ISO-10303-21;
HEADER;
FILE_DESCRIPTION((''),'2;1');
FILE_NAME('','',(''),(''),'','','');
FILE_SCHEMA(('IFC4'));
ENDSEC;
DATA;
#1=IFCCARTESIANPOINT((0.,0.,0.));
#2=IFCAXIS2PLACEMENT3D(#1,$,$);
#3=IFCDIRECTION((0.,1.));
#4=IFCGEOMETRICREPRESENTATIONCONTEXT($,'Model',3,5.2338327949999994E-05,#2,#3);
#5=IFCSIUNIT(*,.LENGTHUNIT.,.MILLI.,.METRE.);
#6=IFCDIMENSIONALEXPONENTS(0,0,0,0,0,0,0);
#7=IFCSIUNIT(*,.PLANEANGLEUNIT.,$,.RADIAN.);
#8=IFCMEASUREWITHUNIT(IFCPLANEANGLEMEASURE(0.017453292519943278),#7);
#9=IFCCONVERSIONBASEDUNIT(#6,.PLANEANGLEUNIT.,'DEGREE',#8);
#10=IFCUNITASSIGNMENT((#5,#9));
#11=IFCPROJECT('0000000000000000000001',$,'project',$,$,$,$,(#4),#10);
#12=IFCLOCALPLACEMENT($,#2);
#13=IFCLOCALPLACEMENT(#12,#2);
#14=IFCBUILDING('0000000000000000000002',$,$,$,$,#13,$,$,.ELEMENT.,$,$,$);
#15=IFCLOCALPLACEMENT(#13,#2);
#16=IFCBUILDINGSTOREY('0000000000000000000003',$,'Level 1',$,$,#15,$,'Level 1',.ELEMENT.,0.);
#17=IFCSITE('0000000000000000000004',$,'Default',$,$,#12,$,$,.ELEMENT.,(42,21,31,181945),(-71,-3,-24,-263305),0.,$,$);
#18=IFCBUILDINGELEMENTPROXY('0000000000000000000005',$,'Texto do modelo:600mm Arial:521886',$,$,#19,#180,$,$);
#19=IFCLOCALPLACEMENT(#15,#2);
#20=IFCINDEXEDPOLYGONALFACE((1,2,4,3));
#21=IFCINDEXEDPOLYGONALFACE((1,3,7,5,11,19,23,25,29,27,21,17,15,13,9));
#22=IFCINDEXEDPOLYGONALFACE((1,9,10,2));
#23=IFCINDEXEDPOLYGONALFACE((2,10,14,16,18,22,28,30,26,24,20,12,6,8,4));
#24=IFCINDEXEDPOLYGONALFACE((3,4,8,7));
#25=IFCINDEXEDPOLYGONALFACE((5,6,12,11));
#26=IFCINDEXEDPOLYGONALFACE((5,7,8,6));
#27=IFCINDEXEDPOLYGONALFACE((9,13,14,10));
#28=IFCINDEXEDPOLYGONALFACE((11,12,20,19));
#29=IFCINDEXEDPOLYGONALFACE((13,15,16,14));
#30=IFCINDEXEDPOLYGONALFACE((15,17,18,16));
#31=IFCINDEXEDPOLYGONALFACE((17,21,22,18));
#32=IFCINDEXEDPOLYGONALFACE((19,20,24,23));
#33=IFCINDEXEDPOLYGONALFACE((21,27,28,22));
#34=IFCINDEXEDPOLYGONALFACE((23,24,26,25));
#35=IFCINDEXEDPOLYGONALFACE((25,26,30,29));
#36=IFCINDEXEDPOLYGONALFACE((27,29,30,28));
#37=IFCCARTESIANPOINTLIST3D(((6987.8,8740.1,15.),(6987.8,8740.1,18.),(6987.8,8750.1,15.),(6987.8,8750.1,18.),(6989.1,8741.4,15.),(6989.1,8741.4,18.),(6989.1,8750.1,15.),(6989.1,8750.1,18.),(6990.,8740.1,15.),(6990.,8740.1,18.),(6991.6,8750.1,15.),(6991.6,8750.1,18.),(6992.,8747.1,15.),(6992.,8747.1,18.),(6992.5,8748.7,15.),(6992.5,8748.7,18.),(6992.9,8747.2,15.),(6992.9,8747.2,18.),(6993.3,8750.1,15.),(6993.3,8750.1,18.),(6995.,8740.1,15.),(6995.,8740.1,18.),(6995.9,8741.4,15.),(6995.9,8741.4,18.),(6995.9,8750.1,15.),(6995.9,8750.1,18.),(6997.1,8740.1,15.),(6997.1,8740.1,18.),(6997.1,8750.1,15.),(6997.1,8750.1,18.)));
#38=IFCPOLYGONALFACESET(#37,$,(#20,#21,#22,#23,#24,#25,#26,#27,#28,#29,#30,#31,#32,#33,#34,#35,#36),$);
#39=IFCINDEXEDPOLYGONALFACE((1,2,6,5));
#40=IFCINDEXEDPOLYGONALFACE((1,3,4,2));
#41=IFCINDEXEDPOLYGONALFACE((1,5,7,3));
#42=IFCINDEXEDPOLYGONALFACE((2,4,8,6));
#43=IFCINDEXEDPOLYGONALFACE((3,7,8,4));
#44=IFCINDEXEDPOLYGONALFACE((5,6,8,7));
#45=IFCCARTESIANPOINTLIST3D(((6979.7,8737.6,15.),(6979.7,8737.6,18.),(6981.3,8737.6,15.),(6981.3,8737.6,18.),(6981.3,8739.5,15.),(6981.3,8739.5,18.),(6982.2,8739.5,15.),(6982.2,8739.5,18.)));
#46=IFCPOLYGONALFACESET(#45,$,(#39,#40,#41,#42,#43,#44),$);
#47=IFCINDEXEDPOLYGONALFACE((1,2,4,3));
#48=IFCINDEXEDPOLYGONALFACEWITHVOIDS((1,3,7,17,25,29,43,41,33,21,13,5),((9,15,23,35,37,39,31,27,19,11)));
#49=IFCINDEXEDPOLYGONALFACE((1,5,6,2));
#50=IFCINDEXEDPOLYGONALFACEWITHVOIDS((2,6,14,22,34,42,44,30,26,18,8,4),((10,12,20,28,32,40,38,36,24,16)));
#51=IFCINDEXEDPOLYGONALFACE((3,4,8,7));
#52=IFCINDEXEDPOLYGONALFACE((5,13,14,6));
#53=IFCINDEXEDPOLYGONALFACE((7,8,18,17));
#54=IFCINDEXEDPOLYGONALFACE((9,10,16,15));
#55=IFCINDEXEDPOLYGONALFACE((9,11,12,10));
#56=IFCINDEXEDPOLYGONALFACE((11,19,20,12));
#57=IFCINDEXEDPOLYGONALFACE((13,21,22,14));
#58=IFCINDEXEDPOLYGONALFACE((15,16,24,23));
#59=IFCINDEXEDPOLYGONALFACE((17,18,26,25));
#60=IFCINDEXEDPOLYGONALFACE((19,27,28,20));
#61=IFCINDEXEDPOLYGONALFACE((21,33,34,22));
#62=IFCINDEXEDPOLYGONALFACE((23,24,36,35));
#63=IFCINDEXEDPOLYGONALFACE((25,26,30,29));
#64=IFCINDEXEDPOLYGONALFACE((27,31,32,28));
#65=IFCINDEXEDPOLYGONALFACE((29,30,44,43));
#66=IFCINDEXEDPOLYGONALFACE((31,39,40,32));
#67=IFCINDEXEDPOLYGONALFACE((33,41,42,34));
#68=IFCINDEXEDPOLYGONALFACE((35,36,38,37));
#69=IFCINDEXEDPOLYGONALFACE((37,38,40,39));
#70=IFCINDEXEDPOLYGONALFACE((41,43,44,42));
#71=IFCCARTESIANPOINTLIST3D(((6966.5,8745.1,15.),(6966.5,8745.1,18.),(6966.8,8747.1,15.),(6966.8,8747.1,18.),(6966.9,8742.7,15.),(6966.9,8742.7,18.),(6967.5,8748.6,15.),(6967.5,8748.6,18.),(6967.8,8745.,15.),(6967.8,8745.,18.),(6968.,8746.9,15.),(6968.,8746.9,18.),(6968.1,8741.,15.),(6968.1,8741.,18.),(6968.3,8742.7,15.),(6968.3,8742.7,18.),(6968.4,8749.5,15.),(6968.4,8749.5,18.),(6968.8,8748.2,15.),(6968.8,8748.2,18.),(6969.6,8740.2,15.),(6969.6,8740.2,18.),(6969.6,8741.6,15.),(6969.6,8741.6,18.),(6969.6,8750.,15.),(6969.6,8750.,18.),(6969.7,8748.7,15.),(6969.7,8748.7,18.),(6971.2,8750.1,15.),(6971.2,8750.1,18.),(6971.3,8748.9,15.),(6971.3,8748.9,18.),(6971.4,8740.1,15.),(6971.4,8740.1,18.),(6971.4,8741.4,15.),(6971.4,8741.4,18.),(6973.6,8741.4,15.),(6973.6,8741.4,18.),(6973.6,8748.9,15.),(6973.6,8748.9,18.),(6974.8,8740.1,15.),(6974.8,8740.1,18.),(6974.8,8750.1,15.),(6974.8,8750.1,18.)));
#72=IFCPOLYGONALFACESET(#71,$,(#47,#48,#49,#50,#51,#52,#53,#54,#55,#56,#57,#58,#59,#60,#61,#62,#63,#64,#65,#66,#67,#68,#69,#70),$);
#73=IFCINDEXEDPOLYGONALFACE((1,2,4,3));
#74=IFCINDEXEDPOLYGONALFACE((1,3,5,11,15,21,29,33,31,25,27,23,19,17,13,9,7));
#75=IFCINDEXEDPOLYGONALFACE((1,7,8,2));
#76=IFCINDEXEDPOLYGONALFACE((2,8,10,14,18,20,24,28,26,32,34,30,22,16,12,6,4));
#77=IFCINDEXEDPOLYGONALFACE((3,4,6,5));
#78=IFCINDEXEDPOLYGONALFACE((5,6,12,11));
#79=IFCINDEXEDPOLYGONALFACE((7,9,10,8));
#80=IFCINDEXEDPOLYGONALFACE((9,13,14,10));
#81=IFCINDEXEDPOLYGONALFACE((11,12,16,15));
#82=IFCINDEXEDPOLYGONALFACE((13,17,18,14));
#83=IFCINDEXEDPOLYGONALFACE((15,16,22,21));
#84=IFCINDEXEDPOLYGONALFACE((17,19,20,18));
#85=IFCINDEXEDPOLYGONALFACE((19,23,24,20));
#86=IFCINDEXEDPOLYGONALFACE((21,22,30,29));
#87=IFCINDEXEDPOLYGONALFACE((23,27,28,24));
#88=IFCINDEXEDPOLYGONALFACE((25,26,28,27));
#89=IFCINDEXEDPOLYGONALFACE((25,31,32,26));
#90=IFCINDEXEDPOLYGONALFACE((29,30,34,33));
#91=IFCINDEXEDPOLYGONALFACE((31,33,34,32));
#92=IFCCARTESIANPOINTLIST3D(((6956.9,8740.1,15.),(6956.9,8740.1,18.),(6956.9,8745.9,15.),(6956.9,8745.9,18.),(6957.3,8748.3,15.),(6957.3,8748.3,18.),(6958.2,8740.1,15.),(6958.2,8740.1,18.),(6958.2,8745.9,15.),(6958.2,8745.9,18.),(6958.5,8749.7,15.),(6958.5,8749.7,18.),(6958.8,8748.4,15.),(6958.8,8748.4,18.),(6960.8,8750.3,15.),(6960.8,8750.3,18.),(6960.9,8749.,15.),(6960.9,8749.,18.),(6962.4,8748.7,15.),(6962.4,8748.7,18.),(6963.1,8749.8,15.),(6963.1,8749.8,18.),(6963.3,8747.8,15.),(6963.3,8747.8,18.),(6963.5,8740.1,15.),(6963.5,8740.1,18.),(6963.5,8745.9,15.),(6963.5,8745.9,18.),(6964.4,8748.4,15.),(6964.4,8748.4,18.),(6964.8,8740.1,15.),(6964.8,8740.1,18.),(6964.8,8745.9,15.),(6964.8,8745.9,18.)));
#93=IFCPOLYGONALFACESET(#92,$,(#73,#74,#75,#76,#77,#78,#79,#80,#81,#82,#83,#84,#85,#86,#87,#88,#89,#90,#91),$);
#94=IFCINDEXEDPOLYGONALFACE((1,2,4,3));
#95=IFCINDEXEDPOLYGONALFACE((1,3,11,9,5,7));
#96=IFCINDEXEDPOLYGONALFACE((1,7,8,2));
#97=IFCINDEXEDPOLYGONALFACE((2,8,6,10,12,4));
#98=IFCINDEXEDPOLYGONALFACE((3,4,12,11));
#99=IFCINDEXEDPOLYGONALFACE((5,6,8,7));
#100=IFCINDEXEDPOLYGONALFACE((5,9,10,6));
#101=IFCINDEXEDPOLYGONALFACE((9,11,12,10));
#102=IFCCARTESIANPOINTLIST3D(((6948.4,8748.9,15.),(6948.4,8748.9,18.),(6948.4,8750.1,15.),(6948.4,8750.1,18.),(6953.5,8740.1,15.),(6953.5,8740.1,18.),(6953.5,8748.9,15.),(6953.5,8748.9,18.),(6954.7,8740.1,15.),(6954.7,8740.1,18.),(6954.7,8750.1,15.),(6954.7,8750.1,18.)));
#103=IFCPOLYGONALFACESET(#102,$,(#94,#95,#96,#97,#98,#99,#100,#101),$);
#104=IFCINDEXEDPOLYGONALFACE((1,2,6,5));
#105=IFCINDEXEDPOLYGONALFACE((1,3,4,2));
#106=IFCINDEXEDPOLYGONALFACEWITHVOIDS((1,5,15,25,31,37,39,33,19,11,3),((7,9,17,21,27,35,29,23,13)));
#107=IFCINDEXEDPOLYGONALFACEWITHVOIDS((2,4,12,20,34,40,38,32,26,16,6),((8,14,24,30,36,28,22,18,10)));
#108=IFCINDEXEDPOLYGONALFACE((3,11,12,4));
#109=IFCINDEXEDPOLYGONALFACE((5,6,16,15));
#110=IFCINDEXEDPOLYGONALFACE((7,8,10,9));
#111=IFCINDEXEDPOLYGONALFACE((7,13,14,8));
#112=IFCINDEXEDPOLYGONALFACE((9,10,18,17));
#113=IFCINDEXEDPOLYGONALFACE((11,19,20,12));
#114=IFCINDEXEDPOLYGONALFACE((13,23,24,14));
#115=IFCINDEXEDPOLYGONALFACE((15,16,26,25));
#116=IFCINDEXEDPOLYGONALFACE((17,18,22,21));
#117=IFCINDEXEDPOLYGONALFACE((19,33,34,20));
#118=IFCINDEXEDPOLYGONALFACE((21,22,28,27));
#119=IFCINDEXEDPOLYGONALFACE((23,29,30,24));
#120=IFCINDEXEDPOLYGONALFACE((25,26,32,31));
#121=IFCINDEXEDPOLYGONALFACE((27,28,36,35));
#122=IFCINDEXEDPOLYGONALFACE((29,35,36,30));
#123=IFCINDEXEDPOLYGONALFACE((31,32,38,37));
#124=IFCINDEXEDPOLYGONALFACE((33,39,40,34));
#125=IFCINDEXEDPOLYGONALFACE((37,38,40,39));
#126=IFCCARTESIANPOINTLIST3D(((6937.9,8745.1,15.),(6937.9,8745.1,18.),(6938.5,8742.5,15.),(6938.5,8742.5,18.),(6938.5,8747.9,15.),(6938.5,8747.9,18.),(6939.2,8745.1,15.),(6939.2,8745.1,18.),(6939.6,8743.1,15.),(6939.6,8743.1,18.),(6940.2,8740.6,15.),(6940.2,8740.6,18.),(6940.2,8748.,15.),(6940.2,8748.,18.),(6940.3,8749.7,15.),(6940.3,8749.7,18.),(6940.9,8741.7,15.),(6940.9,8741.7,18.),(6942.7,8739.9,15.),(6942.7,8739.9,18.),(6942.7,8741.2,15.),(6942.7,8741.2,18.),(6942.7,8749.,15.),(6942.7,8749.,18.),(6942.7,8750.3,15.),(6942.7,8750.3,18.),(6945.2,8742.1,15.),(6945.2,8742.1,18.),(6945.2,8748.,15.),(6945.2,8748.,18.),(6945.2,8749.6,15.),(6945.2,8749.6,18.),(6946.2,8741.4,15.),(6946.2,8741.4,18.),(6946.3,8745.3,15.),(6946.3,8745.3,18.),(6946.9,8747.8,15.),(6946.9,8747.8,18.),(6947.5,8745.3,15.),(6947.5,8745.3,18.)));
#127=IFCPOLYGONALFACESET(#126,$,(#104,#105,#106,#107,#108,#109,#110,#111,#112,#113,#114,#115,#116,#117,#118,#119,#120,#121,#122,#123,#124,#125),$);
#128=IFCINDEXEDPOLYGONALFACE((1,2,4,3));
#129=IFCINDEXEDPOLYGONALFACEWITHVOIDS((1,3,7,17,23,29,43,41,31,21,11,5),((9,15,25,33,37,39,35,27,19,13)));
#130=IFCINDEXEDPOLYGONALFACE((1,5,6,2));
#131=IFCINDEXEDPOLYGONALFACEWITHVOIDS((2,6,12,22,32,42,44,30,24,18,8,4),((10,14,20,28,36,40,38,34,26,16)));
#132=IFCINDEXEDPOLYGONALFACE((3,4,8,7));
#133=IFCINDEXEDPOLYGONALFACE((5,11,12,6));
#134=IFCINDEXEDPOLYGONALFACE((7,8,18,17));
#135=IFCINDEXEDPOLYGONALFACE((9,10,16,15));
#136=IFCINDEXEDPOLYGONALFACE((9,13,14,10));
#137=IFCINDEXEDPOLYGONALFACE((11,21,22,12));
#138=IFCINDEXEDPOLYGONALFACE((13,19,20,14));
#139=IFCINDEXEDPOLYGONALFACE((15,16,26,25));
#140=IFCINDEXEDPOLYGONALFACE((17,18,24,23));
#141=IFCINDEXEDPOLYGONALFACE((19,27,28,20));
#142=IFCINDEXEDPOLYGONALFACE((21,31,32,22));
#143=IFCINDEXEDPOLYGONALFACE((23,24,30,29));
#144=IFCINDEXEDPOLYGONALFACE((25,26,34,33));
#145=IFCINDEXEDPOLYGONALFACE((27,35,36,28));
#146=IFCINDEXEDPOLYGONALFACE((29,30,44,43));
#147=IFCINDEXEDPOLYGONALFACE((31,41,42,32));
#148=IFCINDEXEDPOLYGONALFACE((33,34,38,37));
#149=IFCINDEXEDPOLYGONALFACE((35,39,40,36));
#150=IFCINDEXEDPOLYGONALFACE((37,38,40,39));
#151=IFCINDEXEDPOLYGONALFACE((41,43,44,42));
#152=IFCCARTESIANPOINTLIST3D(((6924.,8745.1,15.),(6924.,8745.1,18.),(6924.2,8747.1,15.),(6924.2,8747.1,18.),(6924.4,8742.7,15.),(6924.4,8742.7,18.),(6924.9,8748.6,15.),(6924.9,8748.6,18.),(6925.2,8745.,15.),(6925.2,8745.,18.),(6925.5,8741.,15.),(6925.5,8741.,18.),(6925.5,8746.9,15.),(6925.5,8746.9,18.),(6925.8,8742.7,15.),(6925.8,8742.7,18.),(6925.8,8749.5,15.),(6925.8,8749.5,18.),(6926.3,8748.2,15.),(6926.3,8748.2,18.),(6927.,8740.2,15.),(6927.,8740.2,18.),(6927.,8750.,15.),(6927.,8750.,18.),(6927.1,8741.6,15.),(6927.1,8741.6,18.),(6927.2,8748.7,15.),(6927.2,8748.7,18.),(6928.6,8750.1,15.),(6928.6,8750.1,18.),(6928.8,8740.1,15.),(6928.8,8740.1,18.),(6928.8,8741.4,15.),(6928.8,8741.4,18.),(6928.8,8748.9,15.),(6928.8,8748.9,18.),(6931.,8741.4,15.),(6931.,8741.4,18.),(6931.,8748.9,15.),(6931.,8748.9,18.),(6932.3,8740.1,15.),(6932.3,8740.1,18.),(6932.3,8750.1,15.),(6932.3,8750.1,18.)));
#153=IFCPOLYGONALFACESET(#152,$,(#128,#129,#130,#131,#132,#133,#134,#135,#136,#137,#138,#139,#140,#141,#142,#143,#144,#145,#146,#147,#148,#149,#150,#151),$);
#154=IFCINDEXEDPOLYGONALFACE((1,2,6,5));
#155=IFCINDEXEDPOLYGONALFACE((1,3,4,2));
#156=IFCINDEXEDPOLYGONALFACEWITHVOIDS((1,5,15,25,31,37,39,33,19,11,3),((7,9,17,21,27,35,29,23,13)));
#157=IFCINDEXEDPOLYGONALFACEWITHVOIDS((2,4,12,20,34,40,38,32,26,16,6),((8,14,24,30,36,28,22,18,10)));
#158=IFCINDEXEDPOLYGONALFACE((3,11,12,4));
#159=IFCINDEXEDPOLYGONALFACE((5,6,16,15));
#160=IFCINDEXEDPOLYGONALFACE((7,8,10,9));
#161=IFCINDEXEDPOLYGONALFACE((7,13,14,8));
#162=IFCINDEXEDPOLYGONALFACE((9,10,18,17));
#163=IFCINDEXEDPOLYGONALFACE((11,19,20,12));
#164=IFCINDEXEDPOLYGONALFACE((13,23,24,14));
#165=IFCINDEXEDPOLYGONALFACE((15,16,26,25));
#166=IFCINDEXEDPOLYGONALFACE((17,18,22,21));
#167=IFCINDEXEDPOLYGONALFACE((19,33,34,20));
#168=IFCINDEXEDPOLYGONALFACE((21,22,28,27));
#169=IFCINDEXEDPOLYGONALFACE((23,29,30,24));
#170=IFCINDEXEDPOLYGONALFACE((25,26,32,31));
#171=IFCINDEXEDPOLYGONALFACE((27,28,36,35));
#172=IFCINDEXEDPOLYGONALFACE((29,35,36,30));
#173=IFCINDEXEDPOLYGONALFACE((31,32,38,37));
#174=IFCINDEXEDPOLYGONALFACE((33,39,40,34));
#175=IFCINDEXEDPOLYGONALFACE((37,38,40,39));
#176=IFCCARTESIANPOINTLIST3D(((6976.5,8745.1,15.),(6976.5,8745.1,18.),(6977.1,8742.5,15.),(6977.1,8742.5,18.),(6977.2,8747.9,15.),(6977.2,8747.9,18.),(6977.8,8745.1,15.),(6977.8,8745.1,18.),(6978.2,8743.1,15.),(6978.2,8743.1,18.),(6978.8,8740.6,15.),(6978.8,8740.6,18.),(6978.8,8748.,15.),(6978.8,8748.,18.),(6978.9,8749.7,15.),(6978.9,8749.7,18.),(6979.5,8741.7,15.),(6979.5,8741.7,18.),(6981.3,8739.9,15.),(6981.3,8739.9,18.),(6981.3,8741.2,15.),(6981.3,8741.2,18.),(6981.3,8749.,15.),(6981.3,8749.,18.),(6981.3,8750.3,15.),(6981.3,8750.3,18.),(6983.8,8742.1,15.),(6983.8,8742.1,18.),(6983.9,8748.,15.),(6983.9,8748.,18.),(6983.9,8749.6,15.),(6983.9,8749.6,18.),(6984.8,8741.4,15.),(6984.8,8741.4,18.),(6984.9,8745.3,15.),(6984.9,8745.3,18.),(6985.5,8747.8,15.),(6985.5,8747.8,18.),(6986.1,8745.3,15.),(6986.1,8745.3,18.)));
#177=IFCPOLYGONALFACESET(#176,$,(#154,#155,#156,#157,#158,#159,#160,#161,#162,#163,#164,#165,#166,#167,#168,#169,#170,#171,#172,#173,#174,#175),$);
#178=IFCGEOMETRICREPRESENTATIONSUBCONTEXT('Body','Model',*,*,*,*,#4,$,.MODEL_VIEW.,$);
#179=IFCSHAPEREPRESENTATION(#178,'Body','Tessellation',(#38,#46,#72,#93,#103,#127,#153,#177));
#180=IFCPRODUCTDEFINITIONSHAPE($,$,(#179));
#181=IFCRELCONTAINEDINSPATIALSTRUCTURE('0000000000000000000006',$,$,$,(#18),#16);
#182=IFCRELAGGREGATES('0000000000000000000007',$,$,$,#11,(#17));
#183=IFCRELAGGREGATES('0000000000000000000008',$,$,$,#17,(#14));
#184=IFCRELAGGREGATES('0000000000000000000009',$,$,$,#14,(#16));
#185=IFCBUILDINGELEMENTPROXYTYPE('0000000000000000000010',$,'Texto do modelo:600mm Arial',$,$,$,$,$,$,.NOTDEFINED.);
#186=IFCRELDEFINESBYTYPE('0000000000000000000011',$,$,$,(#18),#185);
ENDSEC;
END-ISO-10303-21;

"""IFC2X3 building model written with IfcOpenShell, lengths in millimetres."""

from ifc_helpers import new_model, entity, si_unit, converted_unit, direction, frame, origin, place, context, subcontext, project, spatial, polyline, outline, extrude, type_object, element, save


model = new_model("IFC2X3")

# Units and contexts
model_context = context("Model", 3, precision=5.2338327949999994e-05, world=origin(), true_north=direction((0.0, 1.0)))
body_context = subcontext(model_context, "Body", "Model", "MODEL_VIEW")
ifc_project = project(units=[si_unit("LENGTHUNIT", "METRE", prefix="MILLI"), converted_unit("PLANEANGLEUNIT", "DEGREE", entity("IfcPlaneAngleMeasure", 0.017453292519943278), si_unit("PLANEANGLEUNIT", "RADIAN"), dimensions=[0, 0, 0, 0, 0, 0, 0])], contexts=[model_context])

# Site, building, storey
site_placement = place(None, origin())
site = spatial("IfcSite", under=ifc_project, at=site_placement, Name="Default", CompositionType="ELEMENT", RefLatitude=(42, 21, 31, 181945), RefLongitude=(-71, -3, -24, -263305), RefElevation=0.0)
building_placement = place(site_placement, origin())
building = spatial("IfcBuilding", under=site, at=building_placement, CompositionType="ELEMENT")
storey_placement = place(building_placement, origin())
storey = spatial("IfcBuildingStorey", under=building, at=storey_placement, Name="Level 1", LongName="Level 1", CompositionType="ELEMENT", Elevation=0.0)

# Building element proxy
building_element_proxy_type_1 = type_object("IfcBuildingElementProxyType", Name="Texto do modelo:600mm Arial", PredefinedType="NOTDEFINED")
proxy_1_placement = place(storey_placement, origin())
element("IfcBuildingElementProxy", 1, at=proxy_1_placement, inside=storey, type_object=building_element_proxy_type_1, Name="Texto do modelo:600mm Arial:521886", context=body_context, shape_type="SweptSolid", body=[
    extrude(outline(polyline([(-4.6, -4.4), (-3.4, -4.4), (-3.4, 4.4), (-0.9, -4.4), (0.8, -4.4), (3.4, 4.4), (3.4, -4.4), (4.6, -4.4), (4.6, 5.7), (2.5, 5.7), (0.4, -1.3), (0.0, -2.9), (-0.4, -1.4), (-2.5, 5.7), (-4.6, 5.7), (-4.6, -4.4)])), frame((6992.5, 8745.8, 15.0), z_axis=(0.0, 0.0, 1.0), x_axis=(-1.0, 0.0, 0.0)), (0.0, 0.0, 1.0), 3.0),
    extrude(outline(polyline([(-1.1, -0.9), (-0.2, -0.9), (1.4, 0.9), (-0.2, 0.9), (-1.1, -0.9)])), frame((6981.1, 8738.5, 15.0), z_axis=(0.0, 0.0, 1.0), x_axis=(-1.0, 0.0, 0.0)), (0.0, 0.0, 1.0), 3.0),
    extrude(outline(polyline([(-5.2, -4.8), (-1.6, -4.8), (0.0, -4.6), (1.2, -4.1), (2.2, -3.2), (2.8, -1.7), (3.1, 0.3), (2.7, 2.7), (1.5, 4.4), (0.1, 5.1), (-1.7, 5.3), (-5.2, 5.3), (-5.2, -4.8)]), holes=[polyline([(-3.9, -3.5), (-3.9, 4.0), (-1.8, 4.0), (0.0, 3.8), (1.3, 2.7), (1.9, 0.3), (1.6, -1.6), (0.8, -2.8), (-0.1, -3.3), (-1.7, -3.5), (-3.9, -3.5)])]), frame((6969.6, 8745.4, 15.0), z_axis=(0.0, 0.0, 1.0), x_axis=(-1.0, 0.0, 0.0)), (0.0, 0.0, 1.0), 3.0),
    extrude(outline(polyline([(-6.0, -2.8), (-6.0, -4.0), (-0.2, -4.0), (2.2, -3.7), (3.6, -2.5), (4.2, -0.1), (3.7, 2.2), (2.3, 3.4), (-0.2, 3.8), (-6.0, 3.8), (-6.0, 2.6), (-0.3, 2.6), (1.6, 2.3), (2.6, 1.5), (2.9, 0.0), (2.2, -2.1), (-0.3, -2.8), (-6.0, -2.8)])), frame((6961.0, 8746.1, 15.0), z_axis=(0.0, 0.0, -1.0), x_axis=(0.0, 1.0, 0.0)), (0.0, 0.0, -1.0), 3.0),
    extrude(outline(polyline([(-2.5, -3.8), (3.8, -3.8), (3.8, -2.5), (-1.3, -2.5), (-1.3, 6.3), (-2.5, 6.3), (-2.5, -3.8)])), frame((6952.2, 8746.4, 15.0), z_axis=(0.0, 0.0, 1.0), x_axis=(-1.0, 0.0, 0.0)), (0.0, 0.0, 1.0), 3.0),
    extrude(outline(polyline([(-1.3, -4.9), (1.2, -4.9), (3.4, -3.7), (4.7, -1.4), (4.6, 1.1), (3.2, 3.2), (0.7, 4.5), (-2.0, 4.5), (-4.2, 3.2), (-5.4, 1.0), (-4.8, -2.7), (-1.3, -4.9)]), holes=[polyline([(-1.0, -3.7), (-3.9, -2.0), (-4.2, 0.7), (-3.3, 2.4), (-1.7, 3.3), (0.4, 3.2), (3.0, 1.6), (3.4, -1.1), (1.9, -3.3), (-1.0, -3.7)])]), frame((6942.4, 8745.5, 15.0), z_axis=(0.0, 0.0, 1.0), x_axis=(-0.223707, 0.974656, 0.0)), (0.0, 0.0, 1.0), 3.0),
    extrude(outline(polyline([(-5.2, -4.8), (-1.6, -4.8), (0.0, -4.6), (1.2, -4.1), (2.2, -3.2), (2.8, -1.7), (3.1, 0.3), (2.7, 2.7), (1.5, 4.4), (0.1, 5.1), (-1.7, 5.3), (-5.2, 5.3), (-5.2, -4.8)]), holes=[polyline([(-3.9, -3.5), (-3.9, 4.0), (-1.8, 4.0), (0.0, 3.8), (1.3, 2.7), (1.9, 0.3), (1.6, -1.6), (0.8, -2.8), (-0.1, -3.3), (-1.7, -3.5), (-3.9, -3.5)])]), frame((6927.1, 8745.4, 15.0), z_axis=(0.0, 0.0, 1.0), x_axis=(-1.0, 0.0, 0.0)), (0.0, 0.0, 1.0), 3.0),
    extrude(outline(polyline([(-1.3, -4.9), (1.2, -4.9), (3.4, -3.7), (4.7, -1.4), (4.6, 1.1), (3.2, 3.2), (0.7, 4.5), (-2.0, 4.5), (-4.2, 3.2), (-5.4, 1.0), (-4.8, -2.7), (-1.3, -4.9)]), holes=[polyline([(-1.0, -3.7), (-3.9, -2.0), (-4.2, 0.7), (-3.3, 2.4), (-1.7, 3.3), (0.4, 3.2), (3.0, 1.6), (3.4, -1.1), (1.9, -3.3), (-1.0, -3.7)])]), frame((6981.0, 8745.5, 15.0), z_axis=(0.0, 0.0, 1.0), x_axis=(-0.223707, 0.974656, 0.0)), (0.0, 0.0, 1.0), 3.0),
])

save(model, "model.ifc")
